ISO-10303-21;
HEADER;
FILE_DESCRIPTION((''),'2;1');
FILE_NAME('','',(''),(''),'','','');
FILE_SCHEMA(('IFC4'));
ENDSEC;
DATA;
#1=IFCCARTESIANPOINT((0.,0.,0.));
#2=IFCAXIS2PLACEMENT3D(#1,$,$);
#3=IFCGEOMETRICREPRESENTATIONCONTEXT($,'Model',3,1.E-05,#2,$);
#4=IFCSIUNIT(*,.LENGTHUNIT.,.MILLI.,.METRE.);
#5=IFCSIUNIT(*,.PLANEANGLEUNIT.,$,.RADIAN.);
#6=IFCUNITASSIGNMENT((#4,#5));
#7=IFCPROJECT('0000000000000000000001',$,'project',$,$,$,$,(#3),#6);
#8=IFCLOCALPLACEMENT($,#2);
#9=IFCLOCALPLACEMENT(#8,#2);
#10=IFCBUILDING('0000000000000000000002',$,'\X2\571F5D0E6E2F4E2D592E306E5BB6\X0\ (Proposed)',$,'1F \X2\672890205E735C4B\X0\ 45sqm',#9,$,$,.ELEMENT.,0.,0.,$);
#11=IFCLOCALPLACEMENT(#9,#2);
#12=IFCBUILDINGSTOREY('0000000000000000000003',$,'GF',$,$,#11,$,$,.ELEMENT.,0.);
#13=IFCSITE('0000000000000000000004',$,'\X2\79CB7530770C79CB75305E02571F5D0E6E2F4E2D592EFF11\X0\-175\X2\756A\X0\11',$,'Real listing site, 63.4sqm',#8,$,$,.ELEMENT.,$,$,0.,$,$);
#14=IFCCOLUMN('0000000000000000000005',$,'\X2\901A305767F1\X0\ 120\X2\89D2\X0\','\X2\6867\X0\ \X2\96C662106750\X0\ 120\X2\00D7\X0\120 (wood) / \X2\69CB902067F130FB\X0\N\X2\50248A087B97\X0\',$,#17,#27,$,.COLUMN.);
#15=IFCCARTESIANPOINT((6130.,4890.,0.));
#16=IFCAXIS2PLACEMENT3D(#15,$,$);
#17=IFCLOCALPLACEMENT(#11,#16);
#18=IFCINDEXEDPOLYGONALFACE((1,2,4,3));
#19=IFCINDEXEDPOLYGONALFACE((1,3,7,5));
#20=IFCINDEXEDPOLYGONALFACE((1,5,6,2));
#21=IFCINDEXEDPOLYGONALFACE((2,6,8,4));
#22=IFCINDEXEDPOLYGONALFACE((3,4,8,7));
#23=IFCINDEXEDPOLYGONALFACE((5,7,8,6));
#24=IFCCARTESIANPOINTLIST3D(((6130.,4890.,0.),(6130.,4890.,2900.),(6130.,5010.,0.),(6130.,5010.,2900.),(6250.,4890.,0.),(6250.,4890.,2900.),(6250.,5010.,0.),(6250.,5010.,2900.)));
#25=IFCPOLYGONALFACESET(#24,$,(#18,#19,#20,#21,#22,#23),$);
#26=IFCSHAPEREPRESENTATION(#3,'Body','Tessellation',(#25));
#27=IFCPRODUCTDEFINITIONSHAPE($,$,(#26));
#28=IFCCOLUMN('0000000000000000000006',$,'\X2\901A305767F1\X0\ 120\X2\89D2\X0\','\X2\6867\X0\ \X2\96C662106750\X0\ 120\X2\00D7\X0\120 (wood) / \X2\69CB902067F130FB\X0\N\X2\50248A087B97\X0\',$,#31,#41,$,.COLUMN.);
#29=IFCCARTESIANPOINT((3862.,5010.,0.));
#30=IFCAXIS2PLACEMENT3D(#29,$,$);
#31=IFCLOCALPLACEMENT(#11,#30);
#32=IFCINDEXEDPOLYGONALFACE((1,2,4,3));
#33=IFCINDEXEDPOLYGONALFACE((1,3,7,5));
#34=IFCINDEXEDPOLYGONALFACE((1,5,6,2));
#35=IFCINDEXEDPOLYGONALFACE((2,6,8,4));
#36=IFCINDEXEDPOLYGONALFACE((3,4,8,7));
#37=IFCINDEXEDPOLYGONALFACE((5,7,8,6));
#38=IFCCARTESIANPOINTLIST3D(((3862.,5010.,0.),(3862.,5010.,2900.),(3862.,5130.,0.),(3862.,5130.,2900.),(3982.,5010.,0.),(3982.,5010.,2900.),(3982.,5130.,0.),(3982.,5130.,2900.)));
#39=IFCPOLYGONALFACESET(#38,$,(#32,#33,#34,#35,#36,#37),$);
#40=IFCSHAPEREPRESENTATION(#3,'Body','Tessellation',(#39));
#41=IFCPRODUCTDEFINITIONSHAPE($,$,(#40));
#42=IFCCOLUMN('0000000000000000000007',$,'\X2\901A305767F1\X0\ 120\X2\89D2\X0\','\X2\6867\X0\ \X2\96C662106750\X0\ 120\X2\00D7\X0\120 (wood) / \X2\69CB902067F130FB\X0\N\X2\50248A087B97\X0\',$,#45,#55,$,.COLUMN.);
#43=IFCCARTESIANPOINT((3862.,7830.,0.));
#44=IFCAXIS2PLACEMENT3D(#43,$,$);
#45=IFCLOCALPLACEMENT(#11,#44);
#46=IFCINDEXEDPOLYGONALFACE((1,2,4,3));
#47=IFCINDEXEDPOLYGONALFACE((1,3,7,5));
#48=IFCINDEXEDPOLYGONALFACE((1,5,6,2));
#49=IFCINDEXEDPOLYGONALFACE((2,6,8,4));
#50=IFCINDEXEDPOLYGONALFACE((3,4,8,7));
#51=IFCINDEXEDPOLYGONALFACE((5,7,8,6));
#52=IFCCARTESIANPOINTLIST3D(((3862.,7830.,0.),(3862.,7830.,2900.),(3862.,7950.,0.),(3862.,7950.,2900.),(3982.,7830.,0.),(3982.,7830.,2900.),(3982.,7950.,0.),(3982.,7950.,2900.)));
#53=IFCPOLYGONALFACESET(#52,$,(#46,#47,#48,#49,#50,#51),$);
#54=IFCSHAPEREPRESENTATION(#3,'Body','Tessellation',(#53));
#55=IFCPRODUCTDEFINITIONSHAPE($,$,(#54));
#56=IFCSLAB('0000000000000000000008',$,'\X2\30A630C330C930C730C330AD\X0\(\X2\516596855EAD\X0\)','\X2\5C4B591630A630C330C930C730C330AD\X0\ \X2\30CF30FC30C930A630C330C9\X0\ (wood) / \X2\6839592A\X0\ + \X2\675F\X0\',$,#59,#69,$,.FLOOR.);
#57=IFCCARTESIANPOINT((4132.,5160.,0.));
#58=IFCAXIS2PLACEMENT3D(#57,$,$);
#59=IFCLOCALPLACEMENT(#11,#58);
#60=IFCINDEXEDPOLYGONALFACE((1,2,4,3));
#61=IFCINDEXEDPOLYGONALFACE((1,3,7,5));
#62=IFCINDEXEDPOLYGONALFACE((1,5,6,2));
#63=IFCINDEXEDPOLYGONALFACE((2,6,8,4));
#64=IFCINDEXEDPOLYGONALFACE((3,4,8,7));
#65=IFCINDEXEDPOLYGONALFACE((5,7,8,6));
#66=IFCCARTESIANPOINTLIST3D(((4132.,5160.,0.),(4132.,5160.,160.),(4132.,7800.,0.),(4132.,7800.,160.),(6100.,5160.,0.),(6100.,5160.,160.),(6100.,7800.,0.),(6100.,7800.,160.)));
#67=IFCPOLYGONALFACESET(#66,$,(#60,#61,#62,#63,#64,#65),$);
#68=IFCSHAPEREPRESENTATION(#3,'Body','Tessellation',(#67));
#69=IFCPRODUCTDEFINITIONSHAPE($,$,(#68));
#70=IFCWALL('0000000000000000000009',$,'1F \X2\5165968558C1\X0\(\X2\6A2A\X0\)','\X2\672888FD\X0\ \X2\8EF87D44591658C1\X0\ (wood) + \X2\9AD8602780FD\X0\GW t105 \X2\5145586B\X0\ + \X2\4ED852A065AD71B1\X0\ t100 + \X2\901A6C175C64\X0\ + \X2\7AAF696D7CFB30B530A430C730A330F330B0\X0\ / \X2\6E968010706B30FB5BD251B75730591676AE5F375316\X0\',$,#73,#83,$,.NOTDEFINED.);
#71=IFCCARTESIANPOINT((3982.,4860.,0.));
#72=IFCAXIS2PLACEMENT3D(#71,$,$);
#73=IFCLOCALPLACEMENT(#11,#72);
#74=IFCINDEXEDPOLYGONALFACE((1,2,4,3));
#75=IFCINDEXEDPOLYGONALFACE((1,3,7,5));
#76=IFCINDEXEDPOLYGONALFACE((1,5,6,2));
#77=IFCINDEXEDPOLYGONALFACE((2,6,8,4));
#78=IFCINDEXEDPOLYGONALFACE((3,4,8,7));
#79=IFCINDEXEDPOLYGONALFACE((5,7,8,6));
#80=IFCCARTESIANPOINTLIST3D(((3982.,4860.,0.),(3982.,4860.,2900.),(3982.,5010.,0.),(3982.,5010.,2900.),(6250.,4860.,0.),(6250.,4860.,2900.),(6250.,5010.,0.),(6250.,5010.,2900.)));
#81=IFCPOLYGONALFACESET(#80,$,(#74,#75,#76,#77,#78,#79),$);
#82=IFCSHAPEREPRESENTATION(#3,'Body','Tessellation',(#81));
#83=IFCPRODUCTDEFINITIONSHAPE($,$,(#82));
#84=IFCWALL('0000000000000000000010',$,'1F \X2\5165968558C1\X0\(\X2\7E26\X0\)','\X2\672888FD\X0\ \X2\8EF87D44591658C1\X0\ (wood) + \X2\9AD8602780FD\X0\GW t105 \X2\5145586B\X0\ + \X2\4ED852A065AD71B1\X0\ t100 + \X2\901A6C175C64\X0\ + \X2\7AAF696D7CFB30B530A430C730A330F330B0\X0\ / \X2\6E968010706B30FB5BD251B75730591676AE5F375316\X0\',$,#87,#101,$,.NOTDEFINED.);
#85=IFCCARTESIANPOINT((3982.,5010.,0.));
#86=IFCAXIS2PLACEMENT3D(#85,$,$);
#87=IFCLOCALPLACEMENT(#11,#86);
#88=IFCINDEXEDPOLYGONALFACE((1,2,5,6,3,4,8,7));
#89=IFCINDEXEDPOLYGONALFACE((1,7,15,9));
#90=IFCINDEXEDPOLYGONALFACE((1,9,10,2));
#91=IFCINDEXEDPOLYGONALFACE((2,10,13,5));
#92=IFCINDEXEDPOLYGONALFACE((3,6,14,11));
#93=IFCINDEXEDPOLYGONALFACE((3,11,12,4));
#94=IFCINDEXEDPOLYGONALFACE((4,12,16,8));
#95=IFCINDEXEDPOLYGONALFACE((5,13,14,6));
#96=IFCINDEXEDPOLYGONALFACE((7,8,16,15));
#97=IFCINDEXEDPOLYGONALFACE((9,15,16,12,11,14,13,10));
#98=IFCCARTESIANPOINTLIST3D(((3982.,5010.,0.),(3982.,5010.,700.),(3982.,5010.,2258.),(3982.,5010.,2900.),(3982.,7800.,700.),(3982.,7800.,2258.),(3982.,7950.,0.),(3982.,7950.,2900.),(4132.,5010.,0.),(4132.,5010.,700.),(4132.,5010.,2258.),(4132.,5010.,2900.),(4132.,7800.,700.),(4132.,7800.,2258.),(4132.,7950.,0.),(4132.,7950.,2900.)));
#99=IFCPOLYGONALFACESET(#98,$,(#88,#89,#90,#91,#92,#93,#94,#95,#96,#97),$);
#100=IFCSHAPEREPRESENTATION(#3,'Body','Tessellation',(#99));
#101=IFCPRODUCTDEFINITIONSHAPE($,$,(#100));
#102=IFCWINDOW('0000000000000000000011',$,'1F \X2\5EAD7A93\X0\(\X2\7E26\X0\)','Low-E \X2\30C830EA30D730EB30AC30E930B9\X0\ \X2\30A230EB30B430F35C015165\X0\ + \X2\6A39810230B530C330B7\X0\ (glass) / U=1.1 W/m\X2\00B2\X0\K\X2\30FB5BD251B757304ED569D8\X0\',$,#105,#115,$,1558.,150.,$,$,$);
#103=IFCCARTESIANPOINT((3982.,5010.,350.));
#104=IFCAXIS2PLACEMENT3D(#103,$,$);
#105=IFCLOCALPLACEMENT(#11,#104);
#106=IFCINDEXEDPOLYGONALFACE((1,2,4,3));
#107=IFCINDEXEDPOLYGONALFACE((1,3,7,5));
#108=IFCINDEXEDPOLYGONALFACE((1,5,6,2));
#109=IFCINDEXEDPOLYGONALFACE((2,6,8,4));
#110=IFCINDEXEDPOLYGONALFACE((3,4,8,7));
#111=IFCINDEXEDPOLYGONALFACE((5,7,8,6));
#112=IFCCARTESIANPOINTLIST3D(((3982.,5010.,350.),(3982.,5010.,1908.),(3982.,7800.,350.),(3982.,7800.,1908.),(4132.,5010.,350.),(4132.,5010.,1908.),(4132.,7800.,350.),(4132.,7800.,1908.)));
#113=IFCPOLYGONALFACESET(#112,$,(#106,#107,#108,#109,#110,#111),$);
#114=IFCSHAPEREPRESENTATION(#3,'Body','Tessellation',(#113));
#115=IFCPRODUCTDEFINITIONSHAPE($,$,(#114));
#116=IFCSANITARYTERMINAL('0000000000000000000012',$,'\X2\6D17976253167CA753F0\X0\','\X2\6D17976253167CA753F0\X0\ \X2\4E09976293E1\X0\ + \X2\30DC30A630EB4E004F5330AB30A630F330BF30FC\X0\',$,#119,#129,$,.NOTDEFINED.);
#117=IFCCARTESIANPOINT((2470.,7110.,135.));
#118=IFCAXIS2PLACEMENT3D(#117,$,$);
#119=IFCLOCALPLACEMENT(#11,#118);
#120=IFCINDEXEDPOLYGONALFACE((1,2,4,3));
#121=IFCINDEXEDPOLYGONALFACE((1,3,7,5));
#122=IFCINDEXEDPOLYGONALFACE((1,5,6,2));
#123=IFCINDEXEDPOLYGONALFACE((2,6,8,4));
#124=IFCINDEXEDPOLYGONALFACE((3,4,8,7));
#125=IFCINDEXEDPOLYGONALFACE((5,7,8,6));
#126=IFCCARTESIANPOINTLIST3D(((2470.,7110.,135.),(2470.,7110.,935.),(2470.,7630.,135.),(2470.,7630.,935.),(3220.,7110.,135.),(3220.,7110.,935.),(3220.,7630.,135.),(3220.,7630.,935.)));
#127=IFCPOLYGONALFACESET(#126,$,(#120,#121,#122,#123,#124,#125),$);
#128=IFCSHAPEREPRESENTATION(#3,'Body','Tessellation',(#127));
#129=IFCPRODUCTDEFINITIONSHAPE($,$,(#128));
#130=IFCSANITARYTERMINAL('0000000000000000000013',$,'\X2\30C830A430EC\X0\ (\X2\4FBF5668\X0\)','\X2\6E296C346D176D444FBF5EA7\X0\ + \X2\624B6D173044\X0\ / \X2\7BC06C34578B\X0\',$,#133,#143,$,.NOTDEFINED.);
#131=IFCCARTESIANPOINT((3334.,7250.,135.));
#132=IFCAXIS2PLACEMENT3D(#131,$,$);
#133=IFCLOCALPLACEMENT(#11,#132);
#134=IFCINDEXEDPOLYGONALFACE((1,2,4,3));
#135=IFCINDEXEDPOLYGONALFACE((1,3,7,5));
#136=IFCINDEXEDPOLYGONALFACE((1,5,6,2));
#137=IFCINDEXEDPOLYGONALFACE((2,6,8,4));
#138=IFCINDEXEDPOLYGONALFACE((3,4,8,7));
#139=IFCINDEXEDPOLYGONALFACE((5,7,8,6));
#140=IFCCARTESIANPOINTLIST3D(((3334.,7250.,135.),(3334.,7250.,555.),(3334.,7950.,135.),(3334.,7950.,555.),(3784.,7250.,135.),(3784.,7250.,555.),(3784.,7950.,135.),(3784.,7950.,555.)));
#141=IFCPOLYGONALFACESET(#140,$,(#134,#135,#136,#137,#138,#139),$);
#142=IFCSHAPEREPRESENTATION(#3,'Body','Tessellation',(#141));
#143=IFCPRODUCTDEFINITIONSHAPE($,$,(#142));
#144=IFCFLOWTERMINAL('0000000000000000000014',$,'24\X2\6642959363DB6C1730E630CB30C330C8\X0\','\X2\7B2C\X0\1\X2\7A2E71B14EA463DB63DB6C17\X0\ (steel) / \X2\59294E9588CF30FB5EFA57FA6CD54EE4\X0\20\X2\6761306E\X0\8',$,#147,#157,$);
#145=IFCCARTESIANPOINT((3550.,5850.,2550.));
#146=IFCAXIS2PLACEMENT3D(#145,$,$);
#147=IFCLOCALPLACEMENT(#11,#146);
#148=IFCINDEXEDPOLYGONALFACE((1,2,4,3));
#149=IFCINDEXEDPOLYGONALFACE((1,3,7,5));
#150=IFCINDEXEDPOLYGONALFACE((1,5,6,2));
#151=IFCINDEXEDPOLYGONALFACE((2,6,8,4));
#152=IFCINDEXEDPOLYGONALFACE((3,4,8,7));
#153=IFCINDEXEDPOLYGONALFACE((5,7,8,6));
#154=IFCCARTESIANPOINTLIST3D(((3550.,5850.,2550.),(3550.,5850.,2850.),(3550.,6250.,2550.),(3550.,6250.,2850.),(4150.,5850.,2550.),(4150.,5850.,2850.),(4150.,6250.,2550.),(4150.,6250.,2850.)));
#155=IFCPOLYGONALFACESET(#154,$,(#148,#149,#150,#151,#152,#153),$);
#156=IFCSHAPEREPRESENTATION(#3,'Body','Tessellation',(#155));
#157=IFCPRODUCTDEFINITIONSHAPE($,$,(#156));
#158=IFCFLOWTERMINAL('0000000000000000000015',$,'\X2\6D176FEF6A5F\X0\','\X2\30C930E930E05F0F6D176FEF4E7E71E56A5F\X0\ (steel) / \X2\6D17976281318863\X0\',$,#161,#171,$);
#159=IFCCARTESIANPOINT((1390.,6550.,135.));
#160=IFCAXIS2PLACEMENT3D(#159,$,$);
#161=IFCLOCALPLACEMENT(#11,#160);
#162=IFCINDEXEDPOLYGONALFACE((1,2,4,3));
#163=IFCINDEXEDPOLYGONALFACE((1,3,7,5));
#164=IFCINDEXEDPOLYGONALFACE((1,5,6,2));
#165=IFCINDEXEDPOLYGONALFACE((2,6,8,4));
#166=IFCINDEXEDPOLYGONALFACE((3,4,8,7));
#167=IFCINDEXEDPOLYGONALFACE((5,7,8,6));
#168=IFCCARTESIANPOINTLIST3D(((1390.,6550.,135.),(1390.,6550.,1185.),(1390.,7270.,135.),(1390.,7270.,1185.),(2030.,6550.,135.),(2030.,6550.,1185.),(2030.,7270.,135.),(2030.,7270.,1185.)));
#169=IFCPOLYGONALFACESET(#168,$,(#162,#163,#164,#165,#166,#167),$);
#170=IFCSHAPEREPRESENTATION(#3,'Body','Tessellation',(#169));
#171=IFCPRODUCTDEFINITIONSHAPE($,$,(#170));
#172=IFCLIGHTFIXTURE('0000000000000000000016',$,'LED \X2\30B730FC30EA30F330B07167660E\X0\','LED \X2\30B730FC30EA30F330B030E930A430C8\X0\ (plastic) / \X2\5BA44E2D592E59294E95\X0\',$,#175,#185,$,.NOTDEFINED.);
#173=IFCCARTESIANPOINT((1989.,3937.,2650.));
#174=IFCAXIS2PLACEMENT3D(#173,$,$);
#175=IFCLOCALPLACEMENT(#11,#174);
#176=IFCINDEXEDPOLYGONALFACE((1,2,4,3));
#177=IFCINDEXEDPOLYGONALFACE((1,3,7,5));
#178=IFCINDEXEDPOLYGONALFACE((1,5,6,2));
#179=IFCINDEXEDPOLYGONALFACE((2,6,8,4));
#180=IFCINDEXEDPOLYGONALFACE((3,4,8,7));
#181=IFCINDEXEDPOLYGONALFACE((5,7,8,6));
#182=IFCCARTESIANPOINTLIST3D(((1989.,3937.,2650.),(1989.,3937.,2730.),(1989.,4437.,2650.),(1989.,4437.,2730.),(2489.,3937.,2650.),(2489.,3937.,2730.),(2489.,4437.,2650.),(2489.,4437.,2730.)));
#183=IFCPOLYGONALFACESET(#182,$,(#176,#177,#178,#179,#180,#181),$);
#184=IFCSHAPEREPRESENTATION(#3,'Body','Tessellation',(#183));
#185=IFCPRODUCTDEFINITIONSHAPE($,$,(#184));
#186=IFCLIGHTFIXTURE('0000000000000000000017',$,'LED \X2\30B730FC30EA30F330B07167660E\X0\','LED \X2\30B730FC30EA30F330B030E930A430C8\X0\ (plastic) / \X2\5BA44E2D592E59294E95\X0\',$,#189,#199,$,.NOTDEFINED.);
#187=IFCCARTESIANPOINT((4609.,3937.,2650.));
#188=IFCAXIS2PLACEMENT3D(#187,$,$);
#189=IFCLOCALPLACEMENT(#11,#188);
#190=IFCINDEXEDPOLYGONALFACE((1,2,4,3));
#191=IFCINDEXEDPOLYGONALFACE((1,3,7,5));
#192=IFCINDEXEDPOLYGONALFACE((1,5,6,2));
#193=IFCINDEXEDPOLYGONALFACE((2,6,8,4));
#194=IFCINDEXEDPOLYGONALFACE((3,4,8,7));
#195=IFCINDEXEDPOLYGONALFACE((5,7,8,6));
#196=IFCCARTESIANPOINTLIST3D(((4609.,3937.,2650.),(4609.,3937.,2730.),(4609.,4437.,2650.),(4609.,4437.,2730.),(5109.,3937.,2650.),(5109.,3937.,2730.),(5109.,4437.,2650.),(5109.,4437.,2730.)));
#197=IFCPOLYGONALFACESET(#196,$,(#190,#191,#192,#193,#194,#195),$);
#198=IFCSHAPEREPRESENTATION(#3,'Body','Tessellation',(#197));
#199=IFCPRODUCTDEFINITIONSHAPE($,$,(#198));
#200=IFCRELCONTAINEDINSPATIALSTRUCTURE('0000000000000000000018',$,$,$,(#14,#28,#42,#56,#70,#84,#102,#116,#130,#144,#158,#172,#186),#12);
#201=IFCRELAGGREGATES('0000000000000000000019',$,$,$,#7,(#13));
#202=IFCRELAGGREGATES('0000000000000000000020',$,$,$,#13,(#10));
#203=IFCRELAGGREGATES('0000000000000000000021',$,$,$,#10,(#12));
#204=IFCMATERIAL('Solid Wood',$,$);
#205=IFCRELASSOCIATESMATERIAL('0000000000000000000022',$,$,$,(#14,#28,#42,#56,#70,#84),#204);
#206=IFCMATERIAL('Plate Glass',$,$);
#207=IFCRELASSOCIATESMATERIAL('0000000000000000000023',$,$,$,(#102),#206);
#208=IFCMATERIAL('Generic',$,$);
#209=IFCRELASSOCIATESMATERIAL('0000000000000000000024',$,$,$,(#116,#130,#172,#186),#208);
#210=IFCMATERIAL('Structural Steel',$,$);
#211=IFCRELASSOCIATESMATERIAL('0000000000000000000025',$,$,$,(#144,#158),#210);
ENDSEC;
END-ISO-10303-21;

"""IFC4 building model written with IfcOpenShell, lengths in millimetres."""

from ifc_helpers import new_model, si_unit, frame, frame_2d, origin, place, context, project, spatial, rectangle, extrude, material, element, fill, save


model = new_model("IFC4")

# Units and contexts
model_context = context("Model", 3, precision=1e-05, world=origin())
ifc_project = project(units=[si_unit("LENGTHUNIT", "METRE", prefix="MILLI"), si_unit("PLANEANGLEUNIT", "RADIAN")], contexts=[model_context])

# Site, building, storey
site_placement = place(None, origin())
site = spatial("IfcSite", under=ifc_project, at=site_placement, Name="秋田県秋田市土崎港中央１-175番11", ObjectType="Real listing site, 63.4sqm", CompositionType="ELEMENT", RefElevation=0.0)
building_placement = place(site_placement, origin())
building = spatial("IfcBuilding", under=site, at=building_placement, Name="土崎港中央の家 (Proposed)", ObjectType="1F 木造平屋 45sqm", CompositionType="ELEMENT", ElevationOfRefHeight=0.0, ElevationOfTerrain=0.0)
storey_placement = place(building_placement, origin())
storey = spatial("IfcBuildingStorey", under=building, at=storey_placement, Name="GF", CompositionType="ELEMENT", Elevation=0.0)

# Columns
ifc_material_1 = material(Name="Solid Wood")
column_1_placement = place(storey_placement, frame((6130.0, 4890.0, 0.0)))
element("IfcColumn", 1, at=column_1_placement, inside=storey, material=ifc_material_1, Name="通し柱 120角", Description="桧 集成材 120×120 (wood) / 構造柱・N値計算", PredefinedType="COLUMN", context=model_context, shape_type="SweptSolid", body=[
    extrude(rectangle(XDim=120.0, YDim=120.0, at=frame_2d((60.0, 60.0))), frame((6130.0, 4890.0, 0.0)), (0.0, 0.0, 1.0), 2900.0),
])
column_2_placement = place(storey_placement, frame((3862.0, 5010.0, 0.0)))
element("IfcColumn", 2, at=column_2_placement, inside=storey, material=ifc_material_1, Name="通し柱 120角", Description="桧 集成材 120×120 (wood) / 構造柱・N値計算", PredefinedType="COLUMN", context=model_context, shape_type="SweptSolid", body=[
    extrude(rectangle(XDim=120.0, YDim=120.0, at=frame_2d((60.0, 60.0))), frame((3862.0, 5010.0, 0.0)), (0.0, 0.0, 1.0), 2900.0),
])
column_3_placement = place(storey_placement, frame((3862.0, 7830.0, 0.0)))
element("IfcColumn", 3, at=column_3_placement, inside=storey, material=ifc_material_1, Name="通し柱 120角", Description="桧 集成材 120×120 (wood) / 構造柱・N値計算", PredefinedType="COLUMN", context=model_context, shape_type="SweptSolid", body=[
    extrude(rectangle(XDim=120.0, YDim=120.0, at=frame_2d((60.0, 60.0))), frame((3862.0, 7830.0, 0.0)), (0.0, 0.0, 1.0), 2900.0),
])

# Slab
slab_placement = place(storey_placement, frame((4132.0, 5160.0, 0.0)))
element("IfcSlab", 4, at=slab_placement, inside=storey, material=ifc_material_1, Name="ウッドデッキ(入隅庭)", Description="屋外ウッドデッキ ハードウッド (wood) / 根太 + 束", PredefinedType="FLOOR", context=model_context, shape_type="SweptSolid", body=[
    extrude(rectangle(XDim=1968.0, YDim=2640.0, at=frame_2d((984.0, 1320.0))), frame((4132.0, 5160.0, 0.0)), (0.0, 0.0, 1.0), 160.0),
])

# Wall
wall_1_placement = place(storey_placement, frame((3982.0, 4860.0, 0.0)))
element("IfcWall", 5, at=wall_1_placement, inside=storey, material=ifc_material_1, Name="1F 入隅壁(横)", Description="木製 軸組外壁 (wood) + 高性能GW t105 充填 + 付加断熱 t100 + 通気層 + 窯業系サイディング / 準耐火・寒冷地外皮強化", PredefinedType="NOTDEFINED", context=model_context, shape_type="SweptSolid", body=[
    extrude(rectangle(XDim=2268.0, YDim=150.0, at=frame_2d((1134.0, 75.0))), frame((3982.0, 4860.0, 0.0)), (0.0, 0.0, 1.0), 2900.0),
])

# Wall, opening, window
wall_2_placement = place(storey_placement, frame((3982.0, 5010.0, 0.0)))
wall_2 = element("IfcWall", 6, at=wall_2_placement, inside=storey, material=ifc_material_1, Name="1F 入隅壁(縦)", Description="木製 軸組外壁 (wood) + 高性能GW t105 充填 + 付加断熱 t100 + 通気層 + 窯業系サイディング / 準耐火・寒冷地外皮強化", PredefinedType="NOTDEFINED", context=model_context, shape_type="SweptSolid", body=[
    extrude(rectangle(XDim=150.0, YDim=2940.0, at=frame_2d((75.0, 1470.0))), frame((3982.0, 5010.0, 0.0)), (0.0, 0.0, 1.0), 2900.0),
])
opening_placement = place(storey_placement, frame((3982.0, 5010.0, 350.0)))
opening = element("IfcOpeningElement", 7, at=opening_placement, cuts=wall_2, PredefinedType="NOTDEFINED", context=model_context, shape_type="SweptSolid", body=[
    extrude(rectangle(XDim=150.0, YDim=2790.0, at=frame_2d((75.0, 1395.0))), frame((3982.0, 5010.0, 350.0)), (0.0, 0.0, 1.0), 1558.0),
])
ifc_material_2 = material(Name="Plate Glass")
window_placement = place(storey_placement, frame((3982.0, 5010.0, 350.0)))
window = element("IfcWindow", 8, at=window_placement, inside=storey, material=ifc_material_2, Name="1F 庭窓(縦)", Description="Low-E トリプルガラス アルゴン封入 + 樹脂サッシ (glass) / U=1.1 W/m²K・寒冷地仕様", OverallHeight=1558.0, OverallWidth=150.0, context=model_context, shape_type="SweptSolid", body=[
    extrude(rectangle(XDim=150.0, YDim=2790.0, at=frame_2d((75.0, 1395.0))), frame((3982.0, 5010.0, 350.0)), (0.0, 0.0, 1.0), 1558.0),
])
fill(opening, window)

# Sanitary terminals
ifc_material_3 = material(Name="Generic")
sanitary_terminal_1_placement = place(storey_placement, frame((2470.0, 7110.0, 135.0)))
element("IfcSanitaryTerminal", 9, at=sanitary_terminal_1_placement, inside=storey, material=ifc_material_3, Name="洗面化粧台", Description="洗面化粧台 三面鏡 + ボウル一体カウンター", PredefinedType="NOTDEFINED", context=model_context, shape_type="SweptSolid", body=[
    extrude(rectangle(XDim=750.0, YDim=520.0, at=frame_2d((375.0, 260.0))), frame((2470.0, 7110.0, 135.0)), (0.0, 0.0, 1.0), 800.0),
])
sanitary_terminal_2_placement = place(storey_placement, frame((3334.0, 7250.0, 135.0)))
element("IfcSanitaryTerminal", 10, at=sanitary_terminal_2_placement, inside=storey, material=ifc_material_3, Name="トイレ (便器)", Description="温水洗浄便座 + 手洗い / 節水型", PredefinedType="NOTDEFINED", context=model_context, shape_type="SweptSolid", body=[
    extrude(rectangle(XDim=450.0, YDim=700.0, at=frame_2d((225.0, 350.0))), frame((3334.0, 7250.0, 135.0)), (0.0, 0.0, 1.0), 420.0),
])

# Flow terminals
ifc_material_4 = material(Name="Structural Steel")
flow_terminal_1_placement = place(storey_placement, frame((3550.0, 5850.0, 2550.0)))
element("IfcFlowTerminal", 11, at=flow_terminal_1_placement, inside=storey, material=ifc_material_4, Name="24時間換気ユニット", Description="第1種熱交換換気 (steel) / 天井裏・建基法令20条の8", context=model_context, shape_type="SweptSolid", body=[
    extrude(rectangle(XDim=600.0, YDim=400.0, at=frame_2d((300.0, 200.0))), frame((3550.0, 5850.0, 2550.0)), (0.0, 0.0, 1.0), 300.0),
])
flow_terminal_2_placement = place(storey_placement, frame((1390.0, 6550.0, 135.0)))
element("IfcFlowTerminal", 12, at=flow_terminal_2_placement, inside=storey, material=ifc_material_4, Name="洗濯機", Description="ドラム式洗濯乾燥機 (steel) / 洗面脱衣", context=model_context, shape_type="SweptSolid", body=[
    extrude(rectangle(XDim=640.0, YDim=720.0, at=frame_2d((320.0, 360.0))), frame((1390.0, 6550.0, 135.0)), (0.0, 0.0, 1.0), 1050.0),
])

# Light fixtures
light_fixture_1_placement = place(storey_placement, frame((1989.0, 3937.0, 2650.0)))
element("IfcLightFixture", 13, at=light_fixture_1_placement, inside=storey, material=ifc_material_3, Name="LED シーリング照明", Description="LED シーリングライト (plastic) / 室中央天井", PredefinedType="NOTDEFINED", context=model_context, shape_type="SweptSolid", body=[
    extrude(rectangle(XDim=500.0, YDim=500.0, at=frame_2d((250.0, 250.0))), frame((1989.0, 3937.0, 2650.0)), (0.0, 0.0, 1.0), 80.0),
])
light_fixture_2_placement = place(storey_placement, frame((4609.0, 3937.0, 2650.0)))
element("IfcLightFixture", 14, at=light_fixture_2_placement, inside=storey, material=ifc_material_3, Name="LED シーリング照明", Description="LED シーリングライト (plastic) / 室中央天井", PredefinedType="NOTDEFINED", context=model_context, shape_type="SweptSolid", body=[
    extrude(rectangle(XDim=500.0, YDim=500.0, at=frame_2d((250.0, 250.0))), frame((4609.0, 3937.0, 2650.0)), (0.0, 0.0, 1.0), 80.0),
])

save(model, "model.ifc")
